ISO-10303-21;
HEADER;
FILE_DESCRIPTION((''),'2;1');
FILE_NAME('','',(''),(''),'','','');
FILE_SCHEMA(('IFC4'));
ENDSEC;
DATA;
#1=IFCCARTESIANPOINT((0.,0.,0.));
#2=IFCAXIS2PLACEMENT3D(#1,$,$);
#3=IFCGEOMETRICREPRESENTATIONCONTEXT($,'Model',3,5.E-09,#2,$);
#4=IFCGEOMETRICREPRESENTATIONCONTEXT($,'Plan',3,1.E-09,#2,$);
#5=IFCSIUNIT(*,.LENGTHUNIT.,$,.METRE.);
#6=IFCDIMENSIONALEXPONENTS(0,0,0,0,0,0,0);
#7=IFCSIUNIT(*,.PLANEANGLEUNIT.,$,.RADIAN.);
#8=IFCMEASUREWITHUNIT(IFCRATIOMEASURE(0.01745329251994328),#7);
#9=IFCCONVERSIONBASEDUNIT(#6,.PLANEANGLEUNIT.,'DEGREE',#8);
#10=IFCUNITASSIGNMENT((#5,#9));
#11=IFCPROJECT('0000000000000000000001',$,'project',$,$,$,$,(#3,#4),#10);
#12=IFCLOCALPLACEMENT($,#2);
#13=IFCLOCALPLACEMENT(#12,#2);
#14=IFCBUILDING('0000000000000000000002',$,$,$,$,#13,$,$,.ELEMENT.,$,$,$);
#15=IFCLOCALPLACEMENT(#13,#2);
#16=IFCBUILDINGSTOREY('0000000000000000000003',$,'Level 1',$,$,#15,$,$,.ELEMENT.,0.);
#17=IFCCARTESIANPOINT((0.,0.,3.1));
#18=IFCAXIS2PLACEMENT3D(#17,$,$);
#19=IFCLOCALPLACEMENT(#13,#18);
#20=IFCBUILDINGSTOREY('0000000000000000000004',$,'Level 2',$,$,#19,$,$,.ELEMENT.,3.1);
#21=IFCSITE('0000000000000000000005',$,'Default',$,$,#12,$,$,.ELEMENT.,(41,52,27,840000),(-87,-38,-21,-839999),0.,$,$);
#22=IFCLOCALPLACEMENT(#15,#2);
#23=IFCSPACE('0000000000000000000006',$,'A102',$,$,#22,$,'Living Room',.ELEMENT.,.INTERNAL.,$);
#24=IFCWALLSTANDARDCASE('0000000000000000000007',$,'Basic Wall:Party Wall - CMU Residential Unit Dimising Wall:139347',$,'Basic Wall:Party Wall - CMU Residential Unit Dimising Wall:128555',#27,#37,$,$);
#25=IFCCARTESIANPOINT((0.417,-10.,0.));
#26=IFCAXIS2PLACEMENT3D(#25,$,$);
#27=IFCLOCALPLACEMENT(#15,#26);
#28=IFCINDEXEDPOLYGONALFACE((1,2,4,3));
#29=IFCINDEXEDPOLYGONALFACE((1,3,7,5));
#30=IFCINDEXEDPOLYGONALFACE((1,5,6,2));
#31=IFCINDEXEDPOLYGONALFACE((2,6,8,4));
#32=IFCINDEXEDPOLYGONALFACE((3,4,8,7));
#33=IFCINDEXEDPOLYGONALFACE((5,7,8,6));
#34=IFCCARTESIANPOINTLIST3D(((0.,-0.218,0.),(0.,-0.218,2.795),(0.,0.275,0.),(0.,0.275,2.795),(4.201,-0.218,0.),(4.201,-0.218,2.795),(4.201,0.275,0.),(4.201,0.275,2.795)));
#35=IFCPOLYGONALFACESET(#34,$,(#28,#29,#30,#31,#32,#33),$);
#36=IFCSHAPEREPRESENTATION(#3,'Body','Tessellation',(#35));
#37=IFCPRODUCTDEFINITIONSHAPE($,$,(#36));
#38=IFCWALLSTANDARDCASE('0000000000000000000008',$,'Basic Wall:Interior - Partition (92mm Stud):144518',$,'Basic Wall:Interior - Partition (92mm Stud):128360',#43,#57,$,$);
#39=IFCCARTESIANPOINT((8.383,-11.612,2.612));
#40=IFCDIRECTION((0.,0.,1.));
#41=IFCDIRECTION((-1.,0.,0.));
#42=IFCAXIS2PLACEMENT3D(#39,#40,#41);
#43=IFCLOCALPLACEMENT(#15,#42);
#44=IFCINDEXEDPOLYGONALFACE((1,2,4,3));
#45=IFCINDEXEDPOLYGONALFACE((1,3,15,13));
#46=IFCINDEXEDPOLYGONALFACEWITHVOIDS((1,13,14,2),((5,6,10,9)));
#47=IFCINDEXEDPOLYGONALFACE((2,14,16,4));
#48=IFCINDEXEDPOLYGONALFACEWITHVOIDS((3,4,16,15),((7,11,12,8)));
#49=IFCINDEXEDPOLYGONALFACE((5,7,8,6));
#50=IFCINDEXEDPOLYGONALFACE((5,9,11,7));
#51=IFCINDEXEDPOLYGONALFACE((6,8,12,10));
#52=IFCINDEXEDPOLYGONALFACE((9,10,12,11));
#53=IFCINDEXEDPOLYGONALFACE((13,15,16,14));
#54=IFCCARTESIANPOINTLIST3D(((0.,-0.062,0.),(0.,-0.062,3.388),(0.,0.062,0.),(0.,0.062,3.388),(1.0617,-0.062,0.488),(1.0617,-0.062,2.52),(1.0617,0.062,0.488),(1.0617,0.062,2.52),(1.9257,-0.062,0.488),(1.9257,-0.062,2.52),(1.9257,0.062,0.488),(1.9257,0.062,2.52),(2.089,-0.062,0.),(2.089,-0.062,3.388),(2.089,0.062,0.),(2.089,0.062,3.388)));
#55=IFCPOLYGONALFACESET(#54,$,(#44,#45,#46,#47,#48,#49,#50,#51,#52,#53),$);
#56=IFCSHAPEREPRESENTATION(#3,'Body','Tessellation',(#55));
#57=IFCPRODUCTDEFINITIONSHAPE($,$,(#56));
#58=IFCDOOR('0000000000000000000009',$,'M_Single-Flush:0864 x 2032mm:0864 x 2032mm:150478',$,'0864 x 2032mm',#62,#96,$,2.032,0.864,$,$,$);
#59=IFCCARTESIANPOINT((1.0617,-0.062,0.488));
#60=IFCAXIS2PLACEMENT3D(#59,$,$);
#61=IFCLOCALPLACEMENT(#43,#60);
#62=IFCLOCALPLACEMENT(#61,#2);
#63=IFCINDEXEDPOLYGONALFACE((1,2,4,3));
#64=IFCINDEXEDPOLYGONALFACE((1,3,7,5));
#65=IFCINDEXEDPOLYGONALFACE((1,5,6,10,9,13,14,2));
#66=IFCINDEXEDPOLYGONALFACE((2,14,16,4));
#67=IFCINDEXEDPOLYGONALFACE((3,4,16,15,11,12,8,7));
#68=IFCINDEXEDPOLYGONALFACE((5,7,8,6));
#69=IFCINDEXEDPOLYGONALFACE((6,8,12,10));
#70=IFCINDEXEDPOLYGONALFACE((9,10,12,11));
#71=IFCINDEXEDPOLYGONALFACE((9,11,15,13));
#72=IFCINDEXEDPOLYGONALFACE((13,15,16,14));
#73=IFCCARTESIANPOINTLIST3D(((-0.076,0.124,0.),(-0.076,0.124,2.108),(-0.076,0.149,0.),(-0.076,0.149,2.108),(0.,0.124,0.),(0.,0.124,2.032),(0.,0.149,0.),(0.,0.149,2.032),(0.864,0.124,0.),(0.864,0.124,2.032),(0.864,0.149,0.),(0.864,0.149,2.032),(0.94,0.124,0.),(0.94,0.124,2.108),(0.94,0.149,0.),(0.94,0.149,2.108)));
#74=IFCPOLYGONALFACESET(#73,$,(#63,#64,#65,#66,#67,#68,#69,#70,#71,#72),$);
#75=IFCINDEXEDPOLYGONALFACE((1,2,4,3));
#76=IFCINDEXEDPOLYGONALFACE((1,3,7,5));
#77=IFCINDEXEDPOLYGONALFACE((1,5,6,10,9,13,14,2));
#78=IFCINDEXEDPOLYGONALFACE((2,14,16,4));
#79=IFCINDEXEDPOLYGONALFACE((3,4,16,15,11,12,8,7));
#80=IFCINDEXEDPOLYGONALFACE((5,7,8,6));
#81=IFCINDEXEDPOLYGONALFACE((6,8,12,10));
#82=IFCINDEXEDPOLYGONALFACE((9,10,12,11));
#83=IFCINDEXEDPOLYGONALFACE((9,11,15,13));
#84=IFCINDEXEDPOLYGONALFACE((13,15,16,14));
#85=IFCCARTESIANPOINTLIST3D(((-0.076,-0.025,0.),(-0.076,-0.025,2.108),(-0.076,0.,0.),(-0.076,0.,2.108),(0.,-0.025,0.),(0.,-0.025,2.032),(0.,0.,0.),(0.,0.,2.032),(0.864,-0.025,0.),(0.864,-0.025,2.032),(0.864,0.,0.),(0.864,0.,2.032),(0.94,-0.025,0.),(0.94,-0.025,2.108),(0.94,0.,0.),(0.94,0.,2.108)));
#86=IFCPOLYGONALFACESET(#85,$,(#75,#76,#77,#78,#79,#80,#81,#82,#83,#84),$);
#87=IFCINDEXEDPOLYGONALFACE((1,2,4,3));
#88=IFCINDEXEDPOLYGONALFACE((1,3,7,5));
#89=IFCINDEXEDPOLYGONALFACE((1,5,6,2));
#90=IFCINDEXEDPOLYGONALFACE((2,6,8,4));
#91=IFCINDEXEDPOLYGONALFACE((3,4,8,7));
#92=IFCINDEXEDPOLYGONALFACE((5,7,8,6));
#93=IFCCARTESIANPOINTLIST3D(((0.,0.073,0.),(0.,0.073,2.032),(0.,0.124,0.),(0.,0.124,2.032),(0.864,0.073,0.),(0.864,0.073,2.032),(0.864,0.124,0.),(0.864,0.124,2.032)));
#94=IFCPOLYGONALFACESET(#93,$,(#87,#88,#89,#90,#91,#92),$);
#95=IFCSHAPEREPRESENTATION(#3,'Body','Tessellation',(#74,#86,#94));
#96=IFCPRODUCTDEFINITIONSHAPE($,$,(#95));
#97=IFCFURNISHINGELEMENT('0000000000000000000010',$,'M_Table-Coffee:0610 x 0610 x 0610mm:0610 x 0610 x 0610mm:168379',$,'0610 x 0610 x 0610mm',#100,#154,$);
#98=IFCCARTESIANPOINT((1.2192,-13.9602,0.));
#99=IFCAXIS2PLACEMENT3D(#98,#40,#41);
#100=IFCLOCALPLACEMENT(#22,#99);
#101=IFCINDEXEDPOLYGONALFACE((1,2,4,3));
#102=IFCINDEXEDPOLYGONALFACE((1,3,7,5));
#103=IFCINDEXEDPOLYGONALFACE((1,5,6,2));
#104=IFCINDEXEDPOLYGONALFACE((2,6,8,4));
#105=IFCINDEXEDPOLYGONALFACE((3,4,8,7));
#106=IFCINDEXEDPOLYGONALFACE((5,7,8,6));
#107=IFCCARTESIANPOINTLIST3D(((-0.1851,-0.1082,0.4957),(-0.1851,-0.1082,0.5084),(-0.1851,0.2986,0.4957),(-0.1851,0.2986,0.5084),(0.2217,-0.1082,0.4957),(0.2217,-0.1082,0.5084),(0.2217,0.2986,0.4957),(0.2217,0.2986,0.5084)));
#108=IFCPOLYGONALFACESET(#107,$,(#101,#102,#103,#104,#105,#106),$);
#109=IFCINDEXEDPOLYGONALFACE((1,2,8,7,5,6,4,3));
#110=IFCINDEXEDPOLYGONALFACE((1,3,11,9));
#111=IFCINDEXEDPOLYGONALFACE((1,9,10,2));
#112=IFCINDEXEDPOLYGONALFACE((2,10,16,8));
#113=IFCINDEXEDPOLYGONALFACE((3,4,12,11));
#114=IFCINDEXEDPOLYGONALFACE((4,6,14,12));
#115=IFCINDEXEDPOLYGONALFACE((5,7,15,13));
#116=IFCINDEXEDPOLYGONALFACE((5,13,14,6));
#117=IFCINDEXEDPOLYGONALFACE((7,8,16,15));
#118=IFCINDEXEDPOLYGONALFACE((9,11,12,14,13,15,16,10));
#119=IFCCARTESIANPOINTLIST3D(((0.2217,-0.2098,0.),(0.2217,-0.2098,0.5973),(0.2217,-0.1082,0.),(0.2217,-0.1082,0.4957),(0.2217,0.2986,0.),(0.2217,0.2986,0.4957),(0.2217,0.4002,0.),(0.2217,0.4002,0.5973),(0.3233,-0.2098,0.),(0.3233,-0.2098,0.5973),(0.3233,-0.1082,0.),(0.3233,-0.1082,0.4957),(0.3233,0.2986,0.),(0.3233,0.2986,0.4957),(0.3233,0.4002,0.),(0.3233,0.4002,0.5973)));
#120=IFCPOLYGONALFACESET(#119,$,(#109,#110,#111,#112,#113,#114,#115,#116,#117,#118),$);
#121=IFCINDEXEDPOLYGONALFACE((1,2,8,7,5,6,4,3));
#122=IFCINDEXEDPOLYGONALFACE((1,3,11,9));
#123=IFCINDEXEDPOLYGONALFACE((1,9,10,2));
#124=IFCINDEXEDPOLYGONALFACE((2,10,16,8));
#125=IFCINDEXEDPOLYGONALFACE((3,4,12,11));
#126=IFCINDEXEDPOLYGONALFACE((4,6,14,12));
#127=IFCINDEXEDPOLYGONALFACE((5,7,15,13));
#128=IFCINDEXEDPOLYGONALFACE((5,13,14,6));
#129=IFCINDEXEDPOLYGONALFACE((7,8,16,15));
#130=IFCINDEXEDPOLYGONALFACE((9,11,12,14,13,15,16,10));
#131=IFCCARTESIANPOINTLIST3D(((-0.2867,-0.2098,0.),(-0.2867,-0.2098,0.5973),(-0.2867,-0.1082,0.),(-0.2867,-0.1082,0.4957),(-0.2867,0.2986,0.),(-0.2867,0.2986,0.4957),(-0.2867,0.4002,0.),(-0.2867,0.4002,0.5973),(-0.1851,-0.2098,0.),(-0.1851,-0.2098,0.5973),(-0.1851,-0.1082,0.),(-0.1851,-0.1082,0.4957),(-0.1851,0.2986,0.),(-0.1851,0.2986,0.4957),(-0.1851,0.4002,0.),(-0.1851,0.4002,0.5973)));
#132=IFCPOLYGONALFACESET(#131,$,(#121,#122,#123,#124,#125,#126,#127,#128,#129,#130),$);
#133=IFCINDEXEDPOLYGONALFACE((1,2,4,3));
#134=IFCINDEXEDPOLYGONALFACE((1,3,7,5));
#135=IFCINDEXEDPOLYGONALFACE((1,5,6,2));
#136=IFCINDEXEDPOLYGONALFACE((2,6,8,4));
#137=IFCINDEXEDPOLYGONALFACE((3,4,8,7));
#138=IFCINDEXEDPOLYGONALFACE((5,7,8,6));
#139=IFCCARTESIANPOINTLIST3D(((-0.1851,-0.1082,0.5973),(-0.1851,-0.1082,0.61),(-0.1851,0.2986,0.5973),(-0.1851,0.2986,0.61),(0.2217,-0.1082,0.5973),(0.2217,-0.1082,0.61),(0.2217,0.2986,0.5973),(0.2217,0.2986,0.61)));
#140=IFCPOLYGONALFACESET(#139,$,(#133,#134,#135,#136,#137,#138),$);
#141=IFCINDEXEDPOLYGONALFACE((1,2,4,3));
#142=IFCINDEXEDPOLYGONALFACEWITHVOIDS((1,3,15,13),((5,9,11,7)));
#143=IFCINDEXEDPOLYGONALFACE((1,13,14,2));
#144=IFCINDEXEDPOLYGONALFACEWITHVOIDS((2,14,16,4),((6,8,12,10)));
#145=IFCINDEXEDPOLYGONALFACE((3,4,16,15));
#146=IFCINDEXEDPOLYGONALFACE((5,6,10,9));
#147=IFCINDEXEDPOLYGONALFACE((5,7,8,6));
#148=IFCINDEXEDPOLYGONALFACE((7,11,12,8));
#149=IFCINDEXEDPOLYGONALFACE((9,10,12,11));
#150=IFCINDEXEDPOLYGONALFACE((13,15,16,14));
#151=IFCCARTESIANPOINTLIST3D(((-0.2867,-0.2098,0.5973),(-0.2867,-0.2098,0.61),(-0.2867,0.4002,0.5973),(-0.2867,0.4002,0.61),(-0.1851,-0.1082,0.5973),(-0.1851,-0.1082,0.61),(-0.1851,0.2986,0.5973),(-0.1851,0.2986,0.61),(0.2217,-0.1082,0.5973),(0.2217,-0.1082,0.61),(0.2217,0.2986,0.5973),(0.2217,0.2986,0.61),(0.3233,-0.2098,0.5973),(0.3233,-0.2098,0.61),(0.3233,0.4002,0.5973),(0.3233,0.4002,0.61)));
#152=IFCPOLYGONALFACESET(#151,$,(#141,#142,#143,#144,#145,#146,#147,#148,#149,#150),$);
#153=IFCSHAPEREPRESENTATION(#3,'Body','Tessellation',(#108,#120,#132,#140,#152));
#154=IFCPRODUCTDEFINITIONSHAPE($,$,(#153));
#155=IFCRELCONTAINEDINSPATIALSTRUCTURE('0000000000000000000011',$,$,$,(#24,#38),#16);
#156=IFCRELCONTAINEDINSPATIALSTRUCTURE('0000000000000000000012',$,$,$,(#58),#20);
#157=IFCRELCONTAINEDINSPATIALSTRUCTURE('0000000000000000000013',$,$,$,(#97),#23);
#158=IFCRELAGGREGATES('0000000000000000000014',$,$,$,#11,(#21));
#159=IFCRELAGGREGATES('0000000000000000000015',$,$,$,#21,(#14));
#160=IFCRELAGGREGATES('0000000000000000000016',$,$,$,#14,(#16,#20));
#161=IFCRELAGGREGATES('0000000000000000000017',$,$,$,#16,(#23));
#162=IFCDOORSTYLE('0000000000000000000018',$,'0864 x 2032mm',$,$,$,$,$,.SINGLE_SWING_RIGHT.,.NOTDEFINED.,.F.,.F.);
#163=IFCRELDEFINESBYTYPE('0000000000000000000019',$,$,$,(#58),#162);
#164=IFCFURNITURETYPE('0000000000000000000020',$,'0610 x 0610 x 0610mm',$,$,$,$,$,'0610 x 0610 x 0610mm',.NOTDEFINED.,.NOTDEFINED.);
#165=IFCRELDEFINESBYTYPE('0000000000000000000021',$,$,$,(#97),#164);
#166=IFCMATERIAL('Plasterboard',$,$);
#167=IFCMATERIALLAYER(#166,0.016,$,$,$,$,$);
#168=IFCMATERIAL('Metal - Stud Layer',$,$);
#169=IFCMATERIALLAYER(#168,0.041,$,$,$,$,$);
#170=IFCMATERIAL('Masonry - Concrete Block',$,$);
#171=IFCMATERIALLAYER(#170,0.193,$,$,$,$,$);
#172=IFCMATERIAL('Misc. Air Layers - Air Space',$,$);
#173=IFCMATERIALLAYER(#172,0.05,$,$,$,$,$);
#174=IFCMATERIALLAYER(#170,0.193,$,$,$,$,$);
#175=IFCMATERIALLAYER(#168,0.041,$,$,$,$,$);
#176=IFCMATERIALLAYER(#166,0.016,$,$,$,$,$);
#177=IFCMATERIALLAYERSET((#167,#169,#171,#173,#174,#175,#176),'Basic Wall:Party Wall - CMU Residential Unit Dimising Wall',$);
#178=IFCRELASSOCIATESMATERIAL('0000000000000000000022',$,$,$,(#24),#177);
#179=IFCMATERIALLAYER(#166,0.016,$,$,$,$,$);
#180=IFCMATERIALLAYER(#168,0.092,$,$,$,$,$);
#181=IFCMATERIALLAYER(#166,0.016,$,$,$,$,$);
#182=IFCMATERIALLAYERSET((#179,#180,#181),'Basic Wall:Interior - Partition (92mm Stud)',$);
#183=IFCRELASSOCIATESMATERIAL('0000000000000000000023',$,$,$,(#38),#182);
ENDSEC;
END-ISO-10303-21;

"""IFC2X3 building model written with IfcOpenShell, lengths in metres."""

from ifc_helpers import new_model, entity, si_unit, converted_unit, frame, frame_2d, origin, origin_2d_with_axis, place, context, project, spatial, polyline, rectangle, outline, extrude, clip, bounded_halfspace, source, transform, mapped, material, layer, layer_set, layer_usage, type_object, type_shapes, element, fill, save


model = new_model("IFC2X3")

# Units and contexts
model_context = context("Model", 3, precision=5e-09, world=origin())
plan_context = context("Plan", 3, precision=1e-09, world=origin())
ifc_project = project(units=[si_unit("LENGTHUNIT", "METRE"), converted_unit("PLANEANGLEUNIT", "DEGREE", entity("IfcRatioMeasure", 0.01745329251994328), si_unit("PLANEANGLEUNIT", "RADIAN"), dimensions=[0, 0, 0, 0, 0, 0, 0])], contexts=[model_context, plan_context])

# Site, building, storey
site_placement = place(None, origin())
site = spatial("IfcSite", under=ifc_project, at=site_placement, Name="Default", CompositionType="ELEMENT", RefLatitude=(41, 52, 27, 840000), RefLongitude=(-87, -38, -21, -839999), RefElevation=0.0)
building_placement = place(site_placement, origin())
building = spatial("IfcBuilding", under=site, at=building_placement, CompositionType="ELEMENT")
storey_1_placement = place(building_placement, origin())
storey_1 = spatial("IfcBuildingStorey", under=building, at=storey_1_placement, Name="Level 1", CompositionType="ELEMENT", Elevation=0.0)

# Shared definitions
ifc_material_1 = material(Name="Misc. Air Layers - Air Space")
ifc_material_2 = material(Name="Masonry - Concrete Block")
ifc_material_3 = material(Name="Metal - Stud Layer")
ifc_material_4 = material(Name="Plasterboard")

# Wall
ifc_layer_1 = layer(ifc_material_4, 0.016)
ifc_layer_2 = layer(ifc_material_3, 0.041)
ifc_layer_3 = layer(ifc_material_2, 0.193)
ifc_layer_4 = layer(ifc_material_1, 0.05)
ifc_layer_5 = layer(ifc_material_2, 0.193)
ifc_layer_6 = layer(ifc_material_3, 0.041)
ifc_layer_7 = layer(ifc_material_4, 0.016)
ifc_layer_set_1 = layer_set([ifc_layer_1, ifc_layer_2, ifc_layer_3, ifc_layer_4, ifc_layer_5, ifc_layer_6, ifc_layer_7], Name="Basic Wall:Party Wall - CMU Residential Unit Dimising Wall")
ifc_layer_usage_1 = layer_usage(ifc_layer_set_1, "AXIS2", "NEGATIVE", 0.275)
wall_1_placement = place(storey_1_placement, frame((0.417, -10.0, 0.0)))
element("IfcWallStandardCase", 1, at=wall_1_placement, inside=storey_1, material=ifc_layer_usage_1, Name="Basic Wall:Party Wall - CMU Residential Unit Dimising Wall:139347", ObjectType="Basic Wall:Party Wall - CMU Residential Unit Dimising Wall:128555", context=model_context, shape_type="Clipping", body=[
    clip(clip(extrude(rectangle(XDim=4.201, YDim=0.55, at=frame_2d((2.1005, 0.0), x_axis=(-1.0, 0.0))), origin(), (0.0, 0.0, 1.0), 2.795), bounded_halfspace(frame((0.0, -0.218, 0.0), z_axis=(0.0, 1.0, 0.0), x_axis=(-1.0, 0.0, 0.0)), True, frame((0.0, -0.218, 0.0), z_axis=(0.0, 1.0, 0.0), x_axis=(-1.0, 0.0, 0.0)), polyline([(0.0, 0.0), (0.0, 2.795), (-4.201, 2.795), (-4.201, 0.0), (0.0, 0.0)]))), bounded_halfspace(frame((4.201, 0.275, 0.0), z_axis=(-1.0, 0.0, 0.0), x_axis=(0.0, -1.0, 0.0)), True, frame((4.201, 0.275, 0.0), z_axis=(-1.0, 0.0, 0.0), x_axis=(0.0, -1.0, 0.0)), polyline([(0.0, 0.0), (0.493, 0.0), (0.493, 2.795), (0.0, 2.795), (0.0, 0.0)]))),
])
ifc_layer_8 = layer(ifc_material_4, 0.016)
ifc_layer_9 = layer(ifc_material_3, 0.092)
ifc_layer_10 = layer(ifc_material_4, 0.016)
ifc_layer_set_2 = layer_set([ifc_layer_8, ifc_layer_9, ifc_layer_10], Name="Basic Wall:Interior - Partition (92mm Stud)")
ifc_layer_usage_2 = layer_usage(ifc_layer_set_2, "AXIS2", "NEGATIVE", 0.062)

# Wall, opening
wall_2_placement = place(storey_1_placement, frame((8.383, -11.612, 2.612), z_axis=(0.0, 0.0, 1.0), x_axis=(-1.0, 0.0, 0.0)))
wall_2 = element("IfcWallStandardCase", 2, at=wall_2_placement, inside=storey_1, material=ifc_layer_usage_2, Name="Basic Wall:Interior - Partition (92mm Stud):144518", ObjectType="Basic Wall:Interior - Partition (92mm Stud):128360", context=model_context, shape_type="SweptSolid", body=[
    extrude(rectangle(XDim=2.089, YDim=0.124, at=frame_2d((1.0445, 0.0), x_axis=(-1.0, 0.0))), origin(), (0.0, 0.0, 1.0), 3.388),
])
opening_1_placement = place(wall_2_placement, frame((1.0617, -0.062, 0.488)))
opening_1 = element("IfcOpeningElement", 3, at=opening_1_placement, cuts=wall_2, ObjectType="Opening", context=model_context, shape_type="SweptSolid", body=[
    extrude(rectangle(XDim=0.864, YDim=2.032, at=frame_2d((1.016, 0.432), x_axis=(0.0, 1.0))), frame((0.0, 0.0, 0.0), z_axis=(0.0, 1.0, 0.0), x_axis=(0.0, 0.0, 1.0)), (0.0, 0.0, 1.0), 0.124),
])

# Shared definitions
storey_2_placement = place(building_placement, frame((0.0, 0.0, 3.1)))
storey_2 = spatial("IfcBuildingStorey", under=building, at=storey_2_placement, Name="Level 2", CompositionType="ELEMENT", Elevation=3.1)

# Door
door_style_1 = type_object("IfcDoorStyle", Name="0864 x 2032mm", ConstructionType="NOTDEFINED", OperationType="SINGLE_SWING_RIGHT", ParameterTakesPrecedence=False, Sizeable=False)
shared_shape_1 = source(origin(), model_context, "Body", "SweptSolid", [
    extrude(outline(polyline([(-0.508, -1.073), (0.508, -1.073), (0.508, 1.035), (0.432, 1.035), (0.432, -0.997), (-0.432, -0.997), (-0.432, 1.035), (-0.508, 1.035), (-0.508, -1.073)])), frame((0.432, 0.124, 1.035), z_axis=(0.0, 1.0, 0.0), x_axis=(1.0, 0.0, 0.0)), (0.0, 0.0, 1.0), 0.025),
    extrude(outline(polyline([(-1.073, -0.508), (1.035, -0.508), (1.035, -0.432), (-0.997, -0.432), (-0.997, 0.432), (1.035, 0.432), (1.035, 0.508), (-1.073, 0.508), (-1.073, -0.508)])), frame((0.432, -0.025, 1.035), z_axis=(0.0, 1.0, 0.0), x_axis=(0.0, 0.0, -1.0)), (0.0, 0.0, 1.0), 0.025),
    extrude(rectangle(XDim=0.051, YDim=0.864, at=origin_2d_with_axis()), frame((0.432, 0.0985, 0.0), z_axis=(0.0, 0.0, 1.0), x_axis=(0.0, 1.0, 0.0)), (0.0, 0.0, 1.0), 2.032),
])
type_shapes(door_style_1, [shared_shape_1])
door_1_placement = place(opening_1_placement, origin())
door_1 = element("IfcDoor", 4, at=door_1_placement, inside=storey_2, type_object=door_style_1, Name="M_Single-Flush:0864 x 2032mm:0864 x 2032mm:150478", ObjectType="0864 x 2032mm", OverallHeight=2.032, OverallWidth=0.864, context=model_context, shape_type="MappedRepresentation", body=[
    mapped(shared_shape_1, transform((0.0, 0.0, 0.0), scale=1.0)),
])
fill(opening_1, door_1)

# Shared definitions
space_1_placement = place(storey_1_placement, origin())
space_1 = spatial("IfcSpace", under=storey_1, at=space_1_placement, Name="A102", LongName="Living Room", CompositionType="ELEMENT", InteriorOrExteriorSpace="INTERNAL")

# Furnishing element
furniture_type_1 = type_object("IfcFurnitureType", Name="0610 x 0610 x 0610mm", ElementType="0610 x 0610 x 0610mm", AssemblyPlace="NOTDEFINED")
shared_shape_2 = source(origin(), model_context, "Body", "SweptSolid", [
    extrude(rectangle(XDim=0.4068, YDim=0.4068, at=origin_2d_with_axis()), frame((0.0183, 0.0952, 0.4957), z_axis=(0.0, 0.0, 1.0), x_axis=(-1.0, 0.0, 0.0)), (0.0, 0.0, 1.0), 0.0127),
    extrude(outline(polyline([(-0.2732, -0.305), (0.324, -0.305), (0.324, 0.305), (-0.2732, 0.305), (-0.2732, 0.2034), (0.2225, 0.2034), (0.2225, -0.2034), (-0.2732, -0.2034), (-0.2732, -0.305)])), frame((0.2217, 0.0952, 0.2732), z_axis=(1.0, 0.0, 0.0), x_axis=(0.0, 0.0, 1.0)), (0.0, 0.0, 1.0), 0.1016),
    extrude(outline(polyline([(-0.305, -0.3241), (0.305, -0.3241), (0.305, 0.2733), (0.2034, 0.2733), (0.2034, -0.2224), (-0.2034, -0.2224), (-0.2034, 0.2733), (-0.305, 0.2733), (-0.305, -0.3241)])), frame((-0.2867, 0.0952, 0.2733), z_axis=(1.0, 0.0, 0.0), x_axis=(0.0, -1.0, 0.0)), (0.0, 0.0, 1.0), 0.1016),
    extrude(rectangle(XDim=0.4068, YDim=0.4068, at=origin_2d_with_axis()), frame((0.0183, 0.0952, 0.5973), z_axis=(0.0, 0.0, 1.0), x_axis=(-1.0, 0.0, 0.0)), (0.0, 0.0, 1.0), 0.0127),
    extrude(outline(polyline([(-0.305, -0.305), (0.305, -0.305), (0.305, 0.305), (-0.305, 0.305), (-0.305, -0.305)]), holes=[polyline([(-0.2034, -0.2034), (-0.2034, 0.2034), (0.2034, 0.2034), (0.2034, -0.2034), (-0.2034, -0.2034)])]), frame((0.0183, 0.0952, 0.5973), z_axis=(0.0, 0.0, 1.0), x_axis=(-1.0, 0.0, 0.0)), (0.0, 0.0, 1.0), 0.0127),
])
type_shapes(furniture_type_1, [shared_shape_2])
for number, where, z_axis, x_axis, name in (
    (5, (1.2192, -13.9602, 0.0), (0.0, 0.0, 1.0), (-1.0, 0.0, 0.0), "M_Table-Coffee:0610 x 0610 x 0610mm:0610 x 0610 x 0610mm:168379"),
):
    element("IfcFurnishingElement", number, at=place(space_1_placement, frame(where, z_axis=z_axis, x_axis=x_axis)), inside=space_1, type_object=furniture_type_1, Name=name, ObjectType="0610 x 0610 x 0610mm", context=model_context, shape_type="MappedRepresentation", body=[
        mapped(shared_shape_2, transform((0.0, 0.0, 0.0), scale=1.0)),
    ])

save(model, "model.ifc")
